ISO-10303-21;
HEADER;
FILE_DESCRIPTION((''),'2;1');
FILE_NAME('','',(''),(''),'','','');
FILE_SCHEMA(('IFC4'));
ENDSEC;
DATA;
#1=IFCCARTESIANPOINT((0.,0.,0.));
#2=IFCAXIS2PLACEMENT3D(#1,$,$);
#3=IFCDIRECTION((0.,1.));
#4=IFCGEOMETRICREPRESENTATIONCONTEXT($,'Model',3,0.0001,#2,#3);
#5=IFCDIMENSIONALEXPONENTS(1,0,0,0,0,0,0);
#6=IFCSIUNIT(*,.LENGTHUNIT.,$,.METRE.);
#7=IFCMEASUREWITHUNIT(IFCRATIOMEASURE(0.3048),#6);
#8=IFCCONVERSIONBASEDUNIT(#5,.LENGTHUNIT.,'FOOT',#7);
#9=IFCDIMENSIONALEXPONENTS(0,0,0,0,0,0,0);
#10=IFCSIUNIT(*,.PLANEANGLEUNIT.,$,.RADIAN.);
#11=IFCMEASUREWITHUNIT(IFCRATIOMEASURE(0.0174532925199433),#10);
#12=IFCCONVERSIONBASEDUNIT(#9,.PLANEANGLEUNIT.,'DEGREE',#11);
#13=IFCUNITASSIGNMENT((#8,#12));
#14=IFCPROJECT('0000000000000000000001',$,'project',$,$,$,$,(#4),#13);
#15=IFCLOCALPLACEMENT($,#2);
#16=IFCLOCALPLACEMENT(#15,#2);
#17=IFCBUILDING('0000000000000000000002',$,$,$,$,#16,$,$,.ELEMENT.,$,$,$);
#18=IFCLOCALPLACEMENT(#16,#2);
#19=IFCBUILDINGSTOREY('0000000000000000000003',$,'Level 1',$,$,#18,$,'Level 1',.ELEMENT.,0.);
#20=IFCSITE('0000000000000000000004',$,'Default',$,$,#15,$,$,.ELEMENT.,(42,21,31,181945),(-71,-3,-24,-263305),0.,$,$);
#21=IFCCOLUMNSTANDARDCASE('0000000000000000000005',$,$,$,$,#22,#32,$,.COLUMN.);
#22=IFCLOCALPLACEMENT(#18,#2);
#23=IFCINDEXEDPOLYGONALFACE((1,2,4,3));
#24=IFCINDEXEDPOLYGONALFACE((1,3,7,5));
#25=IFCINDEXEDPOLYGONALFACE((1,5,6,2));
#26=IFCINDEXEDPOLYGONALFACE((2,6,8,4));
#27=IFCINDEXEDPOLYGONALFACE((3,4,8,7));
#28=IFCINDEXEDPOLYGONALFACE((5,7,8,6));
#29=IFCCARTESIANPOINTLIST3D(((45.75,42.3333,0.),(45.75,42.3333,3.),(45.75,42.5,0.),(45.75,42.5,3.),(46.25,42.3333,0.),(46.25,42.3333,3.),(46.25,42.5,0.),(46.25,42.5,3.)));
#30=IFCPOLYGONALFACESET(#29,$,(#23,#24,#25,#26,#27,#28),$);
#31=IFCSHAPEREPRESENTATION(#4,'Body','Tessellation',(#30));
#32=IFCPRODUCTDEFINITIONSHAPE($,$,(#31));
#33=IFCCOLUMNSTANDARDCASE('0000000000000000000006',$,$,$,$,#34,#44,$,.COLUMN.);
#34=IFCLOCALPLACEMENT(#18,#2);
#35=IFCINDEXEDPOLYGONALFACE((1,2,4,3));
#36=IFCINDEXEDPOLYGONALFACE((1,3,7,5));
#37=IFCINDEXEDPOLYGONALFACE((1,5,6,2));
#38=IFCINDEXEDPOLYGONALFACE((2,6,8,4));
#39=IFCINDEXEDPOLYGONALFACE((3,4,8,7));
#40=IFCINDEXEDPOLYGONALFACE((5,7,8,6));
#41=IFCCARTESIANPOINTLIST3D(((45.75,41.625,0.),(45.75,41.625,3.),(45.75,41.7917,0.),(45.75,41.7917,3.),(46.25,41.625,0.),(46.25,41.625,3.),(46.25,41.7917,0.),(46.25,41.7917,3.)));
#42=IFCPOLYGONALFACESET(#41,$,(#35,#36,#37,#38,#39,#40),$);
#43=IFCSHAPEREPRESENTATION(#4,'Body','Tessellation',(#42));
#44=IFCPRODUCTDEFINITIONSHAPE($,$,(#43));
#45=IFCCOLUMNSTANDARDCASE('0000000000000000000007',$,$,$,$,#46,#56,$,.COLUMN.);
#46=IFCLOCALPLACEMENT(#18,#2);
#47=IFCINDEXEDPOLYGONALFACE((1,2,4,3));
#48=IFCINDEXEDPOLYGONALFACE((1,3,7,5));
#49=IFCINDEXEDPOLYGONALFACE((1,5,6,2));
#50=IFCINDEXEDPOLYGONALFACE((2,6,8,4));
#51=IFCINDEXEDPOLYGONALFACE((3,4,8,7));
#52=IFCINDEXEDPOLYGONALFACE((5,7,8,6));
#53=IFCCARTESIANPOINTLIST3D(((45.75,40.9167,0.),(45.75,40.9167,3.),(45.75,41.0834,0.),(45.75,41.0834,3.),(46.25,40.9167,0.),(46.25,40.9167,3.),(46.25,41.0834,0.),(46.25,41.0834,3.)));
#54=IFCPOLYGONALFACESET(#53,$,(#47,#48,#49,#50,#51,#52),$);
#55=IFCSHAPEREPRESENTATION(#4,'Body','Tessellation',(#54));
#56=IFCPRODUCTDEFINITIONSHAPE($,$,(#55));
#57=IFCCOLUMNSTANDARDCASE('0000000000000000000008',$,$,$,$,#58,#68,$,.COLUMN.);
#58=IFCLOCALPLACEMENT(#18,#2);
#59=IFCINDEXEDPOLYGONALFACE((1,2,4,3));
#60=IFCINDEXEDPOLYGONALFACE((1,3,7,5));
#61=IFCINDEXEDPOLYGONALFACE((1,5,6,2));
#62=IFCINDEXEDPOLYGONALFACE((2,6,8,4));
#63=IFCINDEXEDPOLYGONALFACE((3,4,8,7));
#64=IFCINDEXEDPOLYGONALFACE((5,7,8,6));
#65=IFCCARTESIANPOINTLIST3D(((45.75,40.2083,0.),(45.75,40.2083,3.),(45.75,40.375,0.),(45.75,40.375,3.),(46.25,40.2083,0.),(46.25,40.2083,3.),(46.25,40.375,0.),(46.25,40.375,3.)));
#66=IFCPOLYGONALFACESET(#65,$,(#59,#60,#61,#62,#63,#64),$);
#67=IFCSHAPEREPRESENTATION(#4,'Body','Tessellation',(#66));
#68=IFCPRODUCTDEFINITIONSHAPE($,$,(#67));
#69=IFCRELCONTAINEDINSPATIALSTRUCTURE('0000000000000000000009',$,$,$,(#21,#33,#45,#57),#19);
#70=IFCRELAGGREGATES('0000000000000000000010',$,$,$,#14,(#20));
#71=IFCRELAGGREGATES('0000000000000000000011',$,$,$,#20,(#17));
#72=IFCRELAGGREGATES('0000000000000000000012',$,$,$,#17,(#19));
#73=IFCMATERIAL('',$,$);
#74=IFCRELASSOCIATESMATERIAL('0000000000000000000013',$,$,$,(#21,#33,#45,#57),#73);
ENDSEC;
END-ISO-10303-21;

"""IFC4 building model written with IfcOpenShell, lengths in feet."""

from ifc_helpers import new_model, entity, si_unit, converted_unit, direction, frame, origin, place, context, project, spatial, rectangle, extrude, material, element, save


model = new_model("IFC4")

# Units and contexts
model_context = context("Model", 3, precision=0.0001, world=origin(), true_north=direction((0.0, 1.0)))
ifc_project = project(units=[converted_unit("LENGTHUNIT", "FOOT", entity("IfcRatioMeasure", 0.3048), si_unit("LENGTHUNIT", "METRE"), dimensions=[1, 0, 0, 0, 0, 0, 0]), converted_unit("PLANEANGLEUNIT", "DEGREE", entity("IfcRatioMeasure", 0.0174532925199433), si_unit("PLANEANGLEUNIT", "RADIAN"), dimensions=[0, 0, 0, 0, 0, 0, 0])], contexts=[model_context])

# Site, building, storey
site_placement = place(None, origin())
site = spatial("IfcSite", under=ifc_project, at=site_placement, Name="Default", CompositionType="ELEMENT", RefLatitude=(42, 21, 31, 181945), RefLongitude=(-71, -3, -24, -263305), RefElevation=0.0)
building_placement = place(site_placement, origin())
building = spatial("IfcBuilding", under=site, at=building_placement, CompositionType="ELEMENT")
storey_placement = place(building_placement, origin())
storey = spatial("IfcBuildingStorey", under=building, at=storey_placement, Name="Level 1", LongName="Level 1", CompositionType="ELEMENT", Elevation=0.0)

# Columns
placement_1 = place(storey_placement, frame((46.0, 46.25, 0.0), z_axis=(0.0, 0.0, 1.0), x_axis=(0.0, -1.0, 0.0)))
ifc_material_1 = material(Name="")
for number, where, z_axis, x_axis in (
    (1, (3.8334, 0.0, 0.0), (0.0, 0.0, 1.0), (1.0, 0.0, 0.0)),
    (2, (4.5417, 0.0, 0.0), (0.0, 0.0, 1.0), (1.0, 0.0, 0.0)),
    (3, (5.25, 0.0, 0.0), (0.0, 0.0, 1.0), (1.0, 0.0, 0.0)),
    (4, (5.9583, 0.0, 0.0), (0.0, 0.0, 1.0), (1.0, 0.0, 0.0)),
):
    element("IfcColumnStandardCase", number, at=place(placement_1, frame(where, z_axis=z_axis, x_axis=x_axis)), inside=storey, material=ifc_material_1, PredefinedType="COLUMN", context=model_context, shape_type="SweptSolid", body=[
        extrude(rectangle(XDim=0.1667, YDim=0.5), origin(), (0.0, 0.0, 1.0), 3.0),
    ])

save(model, "model.ifc")
